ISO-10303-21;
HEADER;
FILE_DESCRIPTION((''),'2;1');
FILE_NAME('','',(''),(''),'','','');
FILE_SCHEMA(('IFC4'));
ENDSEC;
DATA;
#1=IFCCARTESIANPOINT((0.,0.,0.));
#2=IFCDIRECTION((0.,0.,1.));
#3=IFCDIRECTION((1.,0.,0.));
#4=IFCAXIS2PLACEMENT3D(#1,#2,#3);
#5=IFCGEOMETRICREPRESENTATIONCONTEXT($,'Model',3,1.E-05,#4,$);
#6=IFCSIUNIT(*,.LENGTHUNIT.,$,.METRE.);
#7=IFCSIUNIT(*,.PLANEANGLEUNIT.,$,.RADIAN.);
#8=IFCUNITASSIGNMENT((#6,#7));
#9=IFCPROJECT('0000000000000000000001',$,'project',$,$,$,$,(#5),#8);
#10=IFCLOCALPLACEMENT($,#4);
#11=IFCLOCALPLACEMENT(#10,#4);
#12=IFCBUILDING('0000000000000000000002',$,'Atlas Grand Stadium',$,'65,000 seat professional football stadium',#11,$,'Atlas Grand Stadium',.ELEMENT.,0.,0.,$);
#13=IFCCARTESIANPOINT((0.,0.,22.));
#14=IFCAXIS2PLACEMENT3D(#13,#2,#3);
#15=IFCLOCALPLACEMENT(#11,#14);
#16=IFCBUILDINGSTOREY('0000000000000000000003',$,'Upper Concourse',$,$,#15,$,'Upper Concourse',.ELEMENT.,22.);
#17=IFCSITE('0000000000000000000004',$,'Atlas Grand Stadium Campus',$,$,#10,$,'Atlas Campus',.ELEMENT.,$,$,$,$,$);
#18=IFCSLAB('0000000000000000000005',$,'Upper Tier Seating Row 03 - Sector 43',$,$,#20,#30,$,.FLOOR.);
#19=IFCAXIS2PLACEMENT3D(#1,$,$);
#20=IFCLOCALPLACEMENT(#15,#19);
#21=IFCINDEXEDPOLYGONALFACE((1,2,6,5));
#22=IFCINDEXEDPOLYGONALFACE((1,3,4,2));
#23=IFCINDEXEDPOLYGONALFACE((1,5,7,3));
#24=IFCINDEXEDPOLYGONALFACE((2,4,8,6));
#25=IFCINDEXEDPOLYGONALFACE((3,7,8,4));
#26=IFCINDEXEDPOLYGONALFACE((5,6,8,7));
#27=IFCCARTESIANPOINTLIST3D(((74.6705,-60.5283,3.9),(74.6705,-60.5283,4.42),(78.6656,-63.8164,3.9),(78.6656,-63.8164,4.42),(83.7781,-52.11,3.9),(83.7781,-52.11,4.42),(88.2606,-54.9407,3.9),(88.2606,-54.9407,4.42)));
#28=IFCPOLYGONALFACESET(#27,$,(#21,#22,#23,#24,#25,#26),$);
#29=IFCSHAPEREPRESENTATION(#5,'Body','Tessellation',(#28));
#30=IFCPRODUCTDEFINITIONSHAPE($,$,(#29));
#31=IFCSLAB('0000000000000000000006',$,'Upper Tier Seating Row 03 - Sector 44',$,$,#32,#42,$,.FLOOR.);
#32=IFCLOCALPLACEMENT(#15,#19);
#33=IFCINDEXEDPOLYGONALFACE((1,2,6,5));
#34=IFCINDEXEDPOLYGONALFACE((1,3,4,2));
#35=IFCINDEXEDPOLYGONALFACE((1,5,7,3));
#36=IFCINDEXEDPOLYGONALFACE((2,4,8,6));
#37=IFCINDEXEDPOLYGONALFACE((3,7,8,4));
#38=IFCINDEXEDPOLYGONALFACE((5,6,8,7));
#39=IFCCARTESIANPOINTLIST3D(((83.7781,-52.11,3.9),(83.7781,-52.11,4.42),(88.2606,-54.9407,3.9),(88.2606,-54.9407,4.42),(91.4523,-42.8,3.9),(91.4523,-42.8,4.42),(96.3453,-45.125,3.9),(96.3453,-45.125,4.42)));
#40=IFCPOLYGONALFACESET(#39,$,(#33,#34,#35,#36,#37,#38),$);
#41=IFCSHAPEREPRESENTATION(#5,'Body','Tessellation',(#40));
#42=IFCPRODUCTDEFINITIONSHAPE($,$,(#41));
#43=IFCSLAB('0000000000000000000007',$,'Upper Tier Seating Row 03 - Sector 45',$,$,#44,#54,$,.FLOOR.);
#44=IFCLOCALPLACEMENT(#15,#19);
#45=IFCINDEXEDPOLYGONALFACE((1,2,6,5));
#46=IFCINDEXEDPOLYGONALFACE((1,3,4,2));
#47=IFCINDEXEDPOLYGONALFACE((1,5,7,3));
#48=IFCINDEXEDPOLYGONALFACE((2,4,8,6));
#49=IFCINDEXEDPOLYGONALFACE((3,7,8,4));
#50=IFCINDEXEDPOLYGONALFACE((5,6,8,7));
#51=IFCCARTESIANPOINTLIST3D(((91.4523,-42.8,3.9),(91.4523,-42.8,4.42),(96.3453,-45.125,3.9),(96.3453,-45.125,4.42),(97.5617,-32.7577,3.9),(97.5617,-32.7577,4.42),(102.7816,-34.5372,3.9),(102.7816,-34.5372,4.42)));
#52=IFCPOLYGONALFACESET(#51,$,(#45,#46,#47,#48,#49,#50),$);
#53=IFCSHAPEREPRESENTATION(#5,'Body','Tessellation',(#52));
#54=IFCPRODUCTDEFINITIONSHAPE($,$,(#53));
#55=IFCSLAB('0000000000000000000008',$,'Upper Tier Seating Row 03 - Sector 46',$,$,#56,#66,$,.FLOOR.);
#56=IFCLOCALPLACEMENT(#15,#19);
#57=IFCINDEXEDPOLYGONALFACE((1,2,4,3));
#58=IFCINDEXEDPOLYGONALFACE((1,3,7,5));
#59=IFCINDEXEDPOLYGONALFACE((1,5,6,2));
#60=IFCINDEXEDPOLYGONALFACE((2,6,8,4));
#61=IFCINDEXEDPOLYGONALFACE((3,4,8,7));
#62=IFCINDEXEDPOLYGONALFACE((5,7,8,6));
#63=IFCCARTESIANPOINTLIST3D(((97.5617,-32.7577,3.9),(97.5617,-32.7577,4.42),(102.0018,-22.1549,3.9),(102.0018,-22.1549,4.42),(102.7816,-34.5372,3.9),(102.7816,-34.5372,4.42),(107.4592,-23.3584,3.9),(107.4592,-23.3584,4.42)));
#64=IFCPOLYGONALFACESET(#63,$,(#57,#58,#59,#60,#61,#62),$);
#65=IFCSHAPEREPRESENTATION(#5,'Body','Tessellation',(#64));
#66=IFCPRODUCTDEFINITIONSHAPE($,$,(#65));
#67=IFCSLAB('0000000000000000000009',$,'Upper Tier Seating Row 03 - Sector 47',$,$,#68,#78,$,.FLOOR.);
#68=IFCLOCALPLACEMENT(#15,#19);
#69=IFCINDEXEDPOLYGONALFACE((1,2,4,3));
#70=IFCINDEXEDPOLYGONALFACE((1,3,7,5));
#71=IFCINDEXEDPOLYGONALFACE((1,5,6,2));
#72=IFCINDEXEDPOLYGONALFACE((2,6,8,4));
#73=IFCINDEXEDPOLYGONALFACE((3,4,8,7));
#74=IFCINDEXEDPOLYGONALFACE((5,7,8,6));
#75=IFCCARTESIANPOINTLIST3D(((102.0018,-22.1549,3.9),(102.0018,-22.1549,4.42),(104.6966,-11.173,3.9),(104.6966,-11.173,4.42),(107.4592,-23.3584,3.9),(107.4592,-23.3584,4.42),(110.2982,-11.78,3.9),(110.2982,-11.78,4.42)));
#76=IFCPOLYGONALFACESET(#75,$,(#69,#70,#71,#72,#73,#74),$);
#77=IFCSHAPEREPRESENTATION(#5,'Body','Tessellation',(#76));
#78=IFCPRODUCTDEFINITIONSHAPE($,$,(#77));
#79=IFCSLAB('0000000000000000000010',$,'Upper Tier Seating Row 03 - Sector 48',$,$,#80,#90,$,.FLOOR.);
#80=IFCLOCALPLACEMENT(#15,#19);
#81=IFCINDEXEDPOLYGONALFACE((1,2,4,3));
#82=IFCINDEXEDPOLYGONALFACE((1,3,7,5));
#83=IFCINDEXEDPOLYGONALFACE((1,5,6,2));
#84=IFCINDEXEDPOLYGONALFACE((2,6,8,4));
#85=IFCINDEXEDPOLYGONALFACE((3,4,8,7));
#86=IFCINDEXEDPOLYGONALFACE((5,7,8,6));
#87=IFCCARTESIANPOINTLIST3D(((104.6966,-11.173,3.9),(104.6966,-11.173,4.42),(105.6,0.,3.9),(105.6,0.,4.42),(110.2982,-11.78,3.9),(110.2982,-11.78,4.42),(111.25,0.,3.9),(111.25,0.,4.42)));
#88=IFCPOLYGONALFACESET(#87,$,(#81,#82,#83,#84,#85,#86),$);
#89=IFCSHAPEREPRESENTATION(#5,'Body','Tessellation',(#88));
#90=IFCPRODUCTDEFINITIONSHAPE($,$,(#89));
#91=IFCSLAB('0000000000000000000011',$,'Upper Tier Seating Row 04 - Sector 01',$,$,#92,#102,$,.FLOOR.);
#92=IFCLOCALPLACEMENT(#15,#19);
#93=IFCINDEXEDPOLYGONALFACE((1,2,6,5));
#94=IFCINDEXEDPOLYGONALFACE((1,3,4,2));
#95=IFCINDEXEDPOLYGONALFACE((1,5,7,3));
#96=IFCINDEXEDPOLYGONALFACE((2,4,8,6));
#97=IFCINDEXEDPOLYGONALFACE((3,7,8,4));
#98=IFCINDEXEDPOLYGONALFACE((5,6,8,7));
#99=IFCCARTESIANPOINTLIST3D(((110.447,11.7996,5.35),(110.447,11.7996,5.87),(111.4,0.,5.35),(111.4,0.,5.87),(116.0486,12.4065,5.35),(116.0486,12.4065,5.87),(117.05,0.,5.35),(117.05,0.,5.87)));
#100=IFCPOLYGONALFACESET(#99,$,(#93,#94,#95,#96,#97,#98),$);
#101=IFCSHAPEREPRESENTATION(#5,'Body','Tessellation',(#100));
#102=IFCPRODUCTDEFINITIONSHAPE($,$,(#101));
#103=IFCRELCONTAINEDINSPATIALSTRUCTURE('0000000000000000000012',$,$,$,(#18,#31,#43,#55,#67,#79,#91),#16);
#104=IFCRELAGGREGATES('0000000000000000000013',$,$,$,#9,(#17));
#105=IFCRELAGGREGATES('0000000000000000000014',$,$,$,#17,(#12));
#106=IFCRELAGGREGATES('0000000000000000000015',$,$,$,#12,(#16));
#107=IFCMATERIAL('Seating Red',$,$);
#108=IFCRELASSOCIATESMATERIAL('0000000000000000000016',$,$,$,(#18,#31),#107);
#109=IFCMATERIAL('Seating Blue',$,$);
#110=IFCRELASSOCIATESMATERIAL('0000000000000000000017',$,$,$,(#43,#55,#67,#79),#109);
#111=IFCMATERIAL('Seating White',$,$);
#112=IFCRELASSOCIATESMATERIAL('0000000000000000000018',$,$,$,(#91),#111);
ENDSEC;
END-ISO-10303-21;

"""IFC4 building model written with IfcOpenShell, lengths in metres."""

from ifc_helpers import new_model, si_unit, frame, origin_with_axes, place, context, project, spatial, polyline, outline, extrude, material, element, save


model = new_model("IFC4")

# Units and contexts
model_context = context("Model", 3, precision=1e-05, world=origin_with_axes())
ifc_project = project(units=[si_unit("LENGTHUNIT", "METRE"), si_unit("PLANEANGLEUNIT", "RADIAN")], contexts=[model_context])

# Site, building, storey
site_placement = place(None, origin_with_axes())
site = spatial("IfcSite", under=ifc_project, at=site_placement, Name="Atlas Grand Stadium Campus", LongName="Atlas Campus", CompositionType="ELEMENT")
building_placement = place(site_placement, origin_with_axes())
building = spatial("IfcBuilding", under=site, at=building_placement, Name="Atlas Grand Stadium", ObjectType="65,000 seat professional football stadium", LongName="Atlas Grand Stadium", CompositionType="ELEMENT", ElevationOfRefHeight=0.0, ElevationOfTerrain=0.0)
storey_placement = place(building_placement, frame((0.0, 0.0, 22.0), z_axis=(0.0, 0.0, 1.0), x_axis=(1.0, 0.0, 0.0)))
storey = spatial("IfcBuildingStorey", under=building, at=storey_placement, Name="Upper Concourse", LongName="Upper Concourse", CompositionType="ELEMENT", Elevation=22.0)

# Slabs
ifc_material_1 = material(Name="Seating Blue")
ifc_material_2 = material(Name="Seating Red")
ifc_material_3 = material(Name="Seating White")
slab_1_placement = place(storey_placement, frame((0.0, 0.0, 3.9), z_axis=(0.0, 0.0, 1.0), x_axis=(1.0, 0.0, 0.0)))
element("IfcSlab", 1, at=slab_1_placement, inside=storey, material=ifc_material_2, Name="Upper Tier Seating Row 03 - Sector 43", PredefinedType="FLOOR", context=model_context, shape_type="SweptSolid", body=[
    extrude(outline(polyline([(78.6656, -63.8164), (88.2606, -54.9407), (83.7781, -52.11), (74.6705, -60.5283), (78.6656, -63.8164)])), origin_with_axes(), (0.0, 0.0, 1.0), 0.52),
])
slab_2_placement = place(storey_placement, frame((0.0, 0.0, 3.9), z_axis=(0.0, 0.0, 1.0), x_axis=(1.0, 0.0, 0.0)))
element("IfcSlab", 2, at=slab_2_placement, inside=storey, material=ifc_material_2, Name="Upper Tier Seating Row 03 - Sector 44", PredefinedType="FLOOR", context=model_context, shape_type="SweptSolid", body=[
    extrude(outline(polyline([(88.2606, -54.9407), (96.3453, -45.125), (91.4523, -42.8), (83.7781, -52.11), (88.2606, -54.9407)])), origin_with_axes(), (0.0, 0.0, 1.0), 0.52),
])
slab_3_placement = place(storey_placement, frame((0.0, 0.0, 3.9), z_axis=(0.0, 0.0, 1.0), x_axis=(1.0, 0.0, 0.0)))
element("IfcSlab", 3, at=slab_3_placement, inside=storey, material=ifc_material_1, Name="Upper Tier Seating Row 03 - Sector 45", PredefinedType="FLOOR", context=model_context, shape_type="SweptSolid", body=[
    extrude(outline(polyline([(96.3453, -45.125), (102.7816, -34.5372), (97.5617, -32.7577), (91.4523, -42.8), (96.3453, -45.125)])), origin_with_axes(), (0.0, 0.0, 1.0), 0.52),
])
slab_4_placement = place(storey_placement, frame((0.0, 0.0, 3.9), z_axis=(0.0, 0.0, 1.0), x_axis=(1.0, 0.0, 0.0)))
element("IfcSlab", 4, at=slab_4_placement, inside=storey, material=ifc_material_1, Name="Upper Tier Seating Row 03 - Sector 46", PredefinedType="FLOOR", context=model_context, shape_type="SweptSolid", body=[
    extrude(outline(polyline([(102.7816, -34.5372), (107.4592, -23.3584), (102.0018, -22.1549), (97.5617, -32.7577), (102.7816, -34.5372)])), origin_with_axes(), (0.0, 0.0, 1.0), 0.52),
])
slab_5_placement = place(storey_placement, frame((0.0, 0.0, 3.9), z_axis=(0.0, 0.0, 1.0), x_axis=(1.0, 0.0, 0.0)))
element("IfcSlab", 5, at=slab_5_placement, inside=storey, material=ifc_material_1, Name="Upper Tier Seating Row 03 - Sector 47", PredefinedType="FLOOR", context=model_context, shape_type="SweptSolid", body=[
    extrude(outline(polyline([(107.4592, -23.3584), (110.2982, -11.78), (104.6966, -11.173), (102.0018, -22.1549), (107.4592, -23.3584)])), origin_with_axes(), (0.0, 0.0, 1.0), 0.52),
])
slab_6_placement = place(storey_placement, frame((0.0, 0.0, 3.9), z_axis=(0.0, 0.0, 1.0), x_axis=(1.0, 0.0, 0.0)))
element("IfcSlab", 6, at=slab_6_placement, inside=storey, material=ifc_material_1, Name="Upper Tier Seating Row 03 - Sector 48", PredefinedType="FLOOR", context=model_context, shape_type="SweptSolid", body=[
    extrude(outline(polyline([(110.2982, -11.78), (111.25, 0.0), (105.6, 0.0), (104.6966, -11.173), (110.2982, -11.78)])), origin_with_axes(), (0.0, 0.0, 1.0), 0.52),
])
slab_7_placement = place(storey_placement, frame((0.0, 0.0, 5.35), z_axis=(0.0, 0.0, 1.0), x_axis=(1.0, 0.0, 0.0)))
element("IfcSlab", 7, at=slab_7_placement, inside=storey, material=ifc_material_3, Name="Upper Tier Seating Row 04 - Sector 01", PredefinedType="FLOOR", context=model_context, shape_type="SweptSolid", body=[
    extrude(outline(polyline([(117.05, 0.0), (116.0486, 12.4065), (110.447, 11.7996), (111.4, 0.0), (117.05, 0.0)])), origin_with_axes(), (0.0, 0.0, 1.0), 0.52),
])

save(model, "model.ifc")
